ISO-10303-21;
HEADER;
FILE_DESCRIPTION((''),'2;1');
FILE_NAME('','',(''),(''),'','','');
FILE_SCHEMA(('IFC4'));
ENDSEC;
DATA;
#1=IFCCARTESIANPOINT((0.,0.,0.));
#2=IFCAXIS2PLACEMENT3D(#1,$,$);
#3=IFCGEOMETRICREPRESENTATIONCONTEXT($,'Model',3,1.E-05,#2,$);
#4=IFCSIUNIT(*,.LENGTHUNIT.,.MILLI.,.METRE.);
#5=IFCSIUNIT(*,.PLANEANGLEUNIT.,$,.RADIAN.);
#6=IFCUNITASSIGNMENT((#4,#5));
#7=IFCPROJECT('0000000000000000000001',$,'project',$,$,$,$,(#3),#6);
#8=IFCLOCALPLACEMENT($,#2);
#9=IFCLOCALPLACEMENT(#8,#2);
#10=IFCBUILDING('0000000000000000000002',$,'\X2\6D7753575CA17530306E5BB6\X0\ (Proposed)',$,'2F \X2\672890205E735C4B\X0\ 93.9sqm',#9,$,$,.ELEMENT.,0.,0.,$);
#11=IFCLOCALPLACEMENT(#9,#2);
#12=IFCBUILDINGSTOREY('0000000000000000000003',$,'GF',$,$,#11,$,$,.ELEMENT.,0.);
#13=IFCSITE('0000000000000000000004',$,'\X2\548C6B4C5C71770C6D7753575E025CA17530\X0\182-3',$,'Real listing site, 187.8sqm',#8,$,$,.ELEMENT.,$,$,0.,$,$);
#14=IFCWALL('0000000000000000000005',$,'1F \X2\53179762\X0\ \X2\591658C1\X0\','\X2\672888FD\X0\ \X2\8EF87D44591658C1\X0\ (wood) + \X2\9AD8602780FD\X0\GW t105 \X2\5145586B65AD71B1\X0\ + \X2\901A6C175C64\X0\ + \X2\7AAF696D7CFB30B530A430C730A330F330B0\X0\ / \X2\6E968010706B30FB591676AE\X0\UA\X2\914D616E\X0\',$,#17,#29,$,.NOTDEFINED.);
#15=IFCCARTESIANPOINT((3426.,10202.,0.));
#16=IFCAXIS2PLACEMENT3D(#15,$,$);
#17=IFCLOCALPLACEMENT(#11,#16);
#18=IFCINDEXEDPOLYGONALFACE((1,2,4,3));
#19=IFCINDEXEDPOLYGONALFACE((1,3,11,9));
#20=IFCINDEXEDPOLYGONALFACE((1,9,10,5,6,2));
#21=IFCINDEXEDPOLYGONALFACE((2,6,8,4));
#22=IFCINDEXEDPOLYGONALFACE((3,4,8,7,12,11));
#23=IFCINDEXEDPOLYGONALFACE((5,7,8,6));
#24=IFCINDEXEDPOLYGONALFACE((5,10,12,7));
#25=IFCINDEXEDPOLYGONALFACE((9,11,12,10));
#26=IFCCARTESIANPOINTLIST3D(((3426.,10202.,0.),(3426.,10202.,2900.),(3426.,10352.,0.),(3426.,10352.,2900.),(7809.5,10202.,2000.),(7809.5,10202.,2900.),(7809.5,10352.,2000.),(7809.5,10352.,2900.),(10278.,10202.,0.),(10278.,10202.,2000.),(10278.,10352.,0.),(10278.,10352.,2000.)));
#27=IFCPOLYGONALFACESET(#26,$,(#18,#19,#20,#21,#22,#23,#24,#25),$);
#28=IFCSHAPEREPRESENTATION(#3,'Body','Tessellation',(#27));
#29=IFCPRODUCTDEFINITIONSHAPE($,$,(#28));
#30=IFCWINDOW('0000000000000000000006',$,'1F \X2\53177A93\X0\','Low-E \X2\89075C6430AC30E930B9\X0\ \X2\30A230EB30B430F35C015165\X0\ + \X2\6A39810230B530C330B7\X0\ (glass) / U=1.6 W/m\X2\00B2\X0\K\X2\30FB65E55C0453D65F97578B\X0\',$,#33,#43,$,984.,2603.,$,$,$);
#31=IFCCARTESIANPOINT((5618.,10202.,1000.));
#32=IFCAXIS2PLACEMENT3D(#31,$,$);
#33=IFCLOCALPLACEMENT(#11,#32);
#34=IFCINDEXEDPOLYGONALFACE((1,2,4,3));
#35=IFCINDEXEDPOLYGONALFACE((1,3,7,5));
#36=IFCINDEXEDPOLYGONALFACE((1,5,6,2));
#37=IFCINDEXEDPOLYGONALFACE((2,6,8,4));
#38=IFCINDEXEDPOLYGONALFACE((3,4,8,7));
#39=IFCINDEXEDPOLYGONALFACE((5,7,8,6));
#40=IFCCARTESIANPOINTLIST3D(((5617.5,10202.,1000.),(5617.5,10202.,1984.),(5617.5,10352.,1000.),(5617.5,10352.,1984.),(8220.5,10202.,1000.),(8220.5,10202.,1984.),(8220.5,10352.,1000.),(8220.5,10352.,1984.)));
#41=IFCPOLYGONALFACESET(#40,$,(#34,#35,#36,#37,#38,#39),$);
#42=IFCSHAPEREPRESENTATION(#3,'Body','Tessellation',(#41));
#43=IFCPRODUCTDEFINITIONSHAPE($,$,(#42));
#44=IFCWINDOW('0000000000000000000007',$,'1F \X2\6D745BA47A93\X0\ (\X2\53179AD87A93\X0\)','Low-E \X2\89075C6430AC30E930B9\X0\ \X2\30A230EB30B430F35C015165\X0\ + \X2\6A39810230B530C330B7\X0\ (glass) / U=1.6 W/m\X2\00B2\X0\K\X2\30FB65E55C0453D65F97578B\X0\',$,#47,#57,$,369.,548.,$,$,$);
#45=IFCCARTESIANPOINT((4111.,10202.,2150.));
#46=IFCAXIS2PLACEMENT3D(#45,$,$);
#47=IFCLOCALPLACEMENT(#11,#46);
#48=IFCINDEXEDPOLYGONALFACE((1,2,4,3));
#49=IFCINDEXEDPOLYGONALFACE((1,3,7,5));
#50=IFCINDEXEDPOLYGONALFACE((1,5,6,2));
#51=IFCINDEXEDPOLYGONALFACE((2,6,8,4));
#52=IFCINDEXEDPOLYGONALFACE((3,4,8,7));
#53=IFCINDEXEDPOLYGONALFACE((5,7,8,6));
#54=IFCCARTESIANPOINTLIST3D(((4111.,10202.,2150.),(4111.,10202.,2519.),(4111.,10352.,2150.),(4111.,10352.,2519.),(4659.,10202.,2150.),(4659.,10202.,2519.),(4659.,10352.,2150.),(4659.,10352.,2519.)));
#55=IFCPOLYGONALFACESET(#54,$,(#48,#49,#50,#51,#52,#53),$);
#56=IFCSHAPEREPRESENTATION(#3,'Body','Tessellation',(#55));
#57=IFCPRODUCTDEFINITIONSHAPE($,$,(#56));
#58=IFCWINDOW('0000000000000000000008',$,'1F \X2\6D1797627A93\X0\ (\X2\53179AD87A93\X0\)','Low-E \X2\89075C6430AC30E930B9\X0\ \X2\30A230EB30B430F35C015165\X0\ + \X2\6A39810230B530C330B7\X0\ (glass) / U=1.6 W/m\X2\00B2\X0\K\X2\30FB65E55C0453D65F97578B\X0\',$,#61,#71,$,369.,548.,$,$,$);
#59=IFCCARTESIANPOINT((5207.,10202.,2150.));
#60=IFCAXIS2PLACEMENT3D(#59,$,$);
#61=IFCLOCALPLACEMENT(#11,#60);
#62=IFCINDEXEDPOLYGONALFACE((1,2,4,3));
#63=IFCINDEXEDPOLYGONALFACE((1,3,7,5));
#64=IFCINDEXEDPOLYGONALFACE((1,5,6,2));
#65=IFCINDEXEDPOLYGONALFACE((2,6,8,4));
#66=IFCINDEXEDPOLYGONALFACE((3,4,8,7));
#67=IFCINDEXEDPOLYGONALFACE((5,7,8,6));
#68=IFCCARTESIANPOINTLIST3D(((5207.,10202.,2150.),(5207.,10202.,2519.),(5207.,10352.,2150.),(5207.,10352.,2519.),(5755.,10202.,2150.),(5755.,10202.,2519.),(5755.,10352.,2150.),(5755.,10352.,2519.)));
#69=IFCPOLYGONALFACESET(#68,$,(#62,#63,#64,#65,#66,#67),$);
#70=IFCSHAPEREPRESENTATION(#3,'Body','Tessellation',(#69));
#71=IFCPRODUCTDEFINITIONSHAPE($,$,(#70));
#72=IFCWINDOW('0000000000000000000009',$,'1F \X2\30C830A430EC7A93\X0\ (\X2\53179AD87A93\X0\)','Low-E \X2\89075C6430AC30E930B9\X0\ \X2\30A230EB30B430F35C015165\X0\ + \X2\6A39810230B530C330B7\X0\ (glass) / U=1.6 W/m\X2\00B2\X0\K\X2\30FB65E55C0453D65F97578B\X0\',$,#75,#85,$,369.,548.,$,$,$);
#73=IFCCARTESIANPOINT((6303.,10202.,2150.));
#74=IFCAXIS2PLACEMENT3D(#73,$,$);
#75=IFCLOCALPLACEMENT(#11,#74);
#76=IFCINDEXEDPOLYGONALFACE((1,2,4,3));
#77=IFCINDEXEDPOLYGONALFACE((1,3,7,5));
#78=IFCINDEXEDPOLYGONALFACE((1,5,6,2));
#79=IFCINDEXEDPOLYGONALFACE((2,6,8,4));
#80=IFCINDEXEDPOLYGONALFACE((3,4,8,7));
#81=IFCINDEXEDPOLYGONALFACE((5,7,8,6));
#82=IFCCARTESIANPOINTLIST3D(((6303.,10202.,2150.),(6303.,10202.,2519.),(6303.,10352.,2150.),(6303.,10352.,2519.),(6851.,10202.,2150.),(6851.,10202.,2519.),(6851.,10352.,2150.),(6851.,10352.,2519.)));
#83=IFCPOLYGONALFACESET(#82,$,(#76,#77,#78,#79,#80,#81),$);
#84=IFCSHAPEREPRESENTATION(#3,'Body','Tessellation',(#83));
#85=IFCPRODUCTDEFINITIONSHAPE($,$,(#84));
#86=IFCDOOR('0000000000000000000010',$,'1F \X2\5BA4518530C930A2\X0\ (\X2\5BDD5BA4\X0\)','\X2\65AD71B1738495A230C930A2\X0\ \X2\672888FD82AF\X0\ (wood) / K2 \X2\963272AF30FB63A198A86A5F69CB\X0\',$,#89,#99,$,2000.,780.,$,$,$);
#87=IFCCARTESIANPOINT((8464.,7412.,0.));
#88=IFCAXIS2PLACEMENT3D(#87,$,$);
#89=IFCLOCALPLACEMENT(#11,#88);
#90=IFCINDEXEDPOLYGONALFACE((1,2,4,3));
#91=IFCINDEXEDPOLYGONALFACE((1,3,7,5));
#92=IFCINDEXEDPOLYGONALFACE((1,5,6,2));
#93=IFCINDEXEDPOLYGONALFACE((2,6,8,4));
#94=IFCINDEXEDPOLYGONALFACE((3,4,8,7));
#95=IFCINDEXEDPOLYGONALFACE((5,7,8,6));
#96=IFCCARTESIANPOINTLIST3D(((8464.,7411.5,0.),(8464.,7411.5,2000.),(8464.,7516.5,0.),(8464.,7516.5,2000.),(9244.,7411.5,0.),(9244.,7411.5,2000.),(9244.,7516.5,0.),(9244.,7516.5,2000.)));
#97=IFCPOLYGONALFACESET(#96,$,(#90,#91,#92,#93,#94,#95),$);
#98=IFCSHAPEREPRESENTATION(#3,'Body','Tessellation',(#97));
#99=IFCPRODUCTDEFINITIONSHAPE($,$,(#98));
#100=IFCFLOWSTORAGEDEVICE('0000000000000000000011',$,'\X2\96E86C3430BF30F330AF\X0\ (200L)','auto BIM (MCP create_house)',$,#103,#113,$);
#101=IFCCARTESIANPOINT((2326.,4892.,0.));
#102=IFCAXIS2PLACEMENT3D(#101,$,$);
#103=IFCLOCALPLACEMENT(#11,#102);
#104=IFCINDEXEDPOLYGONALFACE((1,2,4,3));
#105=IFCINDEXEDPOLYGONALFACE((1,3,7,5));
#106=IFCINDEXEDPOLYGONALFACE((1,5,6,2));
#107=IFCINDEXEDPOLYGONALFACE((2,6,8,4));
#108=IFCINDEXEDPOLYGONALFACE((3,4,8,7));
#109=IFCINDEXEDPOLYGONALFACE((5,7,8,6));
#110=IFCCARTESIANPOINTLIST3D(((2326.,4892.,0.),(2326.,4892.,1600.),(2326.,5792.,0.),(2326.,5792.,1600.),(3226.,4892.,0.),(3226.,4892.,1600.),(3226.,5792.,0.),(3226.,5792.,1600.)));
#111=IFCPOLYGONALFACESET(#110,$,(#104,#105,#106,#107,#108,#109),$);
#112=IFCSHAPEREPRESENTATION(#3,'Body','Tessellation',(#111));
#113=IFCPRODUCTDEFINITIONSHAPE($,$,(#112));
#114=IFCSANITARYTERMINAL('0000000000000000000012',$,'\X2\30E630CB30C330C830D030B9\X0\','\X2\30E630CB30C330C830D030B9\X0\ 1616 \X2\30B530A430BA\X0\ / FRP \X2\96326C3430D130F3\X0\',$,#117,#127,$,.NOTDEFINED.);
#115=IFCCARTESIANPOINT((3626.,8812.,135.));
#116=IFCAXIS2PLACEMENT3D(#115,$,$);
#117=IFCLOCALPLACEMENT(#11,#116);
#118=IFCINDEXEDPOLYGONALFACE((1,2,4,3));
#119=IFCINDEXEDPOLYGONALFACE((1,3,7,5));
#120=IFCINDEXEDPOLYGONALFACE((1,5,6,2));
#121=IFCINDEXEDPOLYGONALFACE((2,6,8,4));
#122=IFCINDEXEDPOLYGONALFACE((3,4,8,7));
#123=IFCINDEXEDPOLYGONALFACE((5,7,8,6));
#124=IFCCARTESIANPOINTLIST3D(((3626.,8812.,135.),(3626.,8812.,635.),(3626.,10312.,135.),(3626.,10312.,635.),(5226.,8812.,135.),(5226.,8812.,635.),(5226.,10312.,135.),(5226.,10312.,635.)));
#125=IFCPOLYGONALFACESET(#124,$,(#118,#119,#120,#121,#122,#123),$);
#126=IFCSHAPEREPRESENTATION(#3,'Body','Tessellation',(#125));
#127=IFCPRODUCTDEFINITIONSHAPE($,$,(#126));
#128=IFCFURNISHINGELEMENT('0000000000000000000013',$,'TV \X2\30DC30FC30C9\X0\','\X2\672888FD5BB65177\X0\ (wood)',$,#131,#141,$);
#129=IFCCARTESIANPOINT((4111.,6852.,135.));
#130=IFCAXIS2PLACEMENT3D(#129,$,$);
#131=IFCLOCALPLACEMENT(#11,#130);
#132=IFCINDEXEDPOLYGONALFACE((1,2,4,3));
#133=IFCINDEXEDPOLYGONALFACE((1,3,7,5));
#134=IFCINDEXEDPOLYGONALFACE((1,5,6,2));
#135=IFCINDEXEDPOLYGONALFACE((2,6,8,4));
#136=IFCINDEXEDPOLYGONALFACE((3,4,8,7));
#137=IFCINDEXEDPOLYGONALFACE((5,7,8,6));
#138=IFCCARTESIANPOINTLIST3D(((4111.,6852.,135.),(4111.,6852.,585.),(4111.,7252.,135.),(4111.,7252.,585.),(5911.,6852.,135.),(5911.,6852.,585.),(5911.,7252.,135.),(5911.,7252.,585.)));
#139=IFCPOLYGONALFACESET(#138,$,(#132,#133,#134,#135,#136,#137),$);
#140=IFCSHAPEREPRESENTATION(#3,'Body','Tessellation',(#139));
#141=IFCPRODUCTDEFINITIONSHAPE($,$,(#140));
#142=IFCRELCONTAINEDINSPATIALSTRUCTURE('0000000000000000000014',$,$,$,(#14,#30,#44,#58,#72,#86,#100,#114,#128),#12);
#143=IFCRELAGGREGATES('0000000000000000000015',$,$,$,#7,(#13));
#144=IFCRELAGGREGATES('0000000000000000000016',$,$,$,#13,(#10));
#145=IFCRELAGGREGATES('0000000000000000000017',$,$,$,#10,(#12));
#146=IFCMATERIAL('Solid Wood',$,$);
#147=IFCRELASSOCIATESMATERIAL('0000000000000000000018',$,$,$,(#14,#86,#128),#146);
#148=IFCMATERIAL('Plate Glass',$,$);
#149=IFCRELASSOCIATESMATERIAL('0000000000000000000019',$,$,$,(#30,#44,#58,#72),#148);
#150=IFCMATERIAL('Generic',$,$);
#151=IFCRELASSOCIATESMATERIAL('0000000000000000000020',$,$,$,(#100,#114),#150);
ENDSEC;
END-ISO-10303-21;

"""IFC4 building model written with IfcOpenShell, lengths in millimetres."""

from ifc_helpers import new_model, si_unit, frame, frame_2d, origin, place, context, project, spatial, rectangle, extrude, material, element, fill, save


model = new_model("IFC4")

# Units and contexts
model_context = context("Model", 3, precision=1e-05, world=origin())
ifc_project = project(units=[si_unit("LENGTHUNIT", "METRE", prefix="MILLI"), si_unit("PLANEANGLEUNIT", "RADIAN")], contexts=[model_context])

# Site, building, storey
site_placement = place(None, origin())
site = spatial("IfcSite", under=ifc_project, at=site_placement, Name="和歌山県海南市岡田182-3", ObjectType="Real listing site, 187.8sqm", CompositionType="ELEMENT", RefElevation=0.0)
building_placement = place(site_placement, origin())
building = spatial("IfcBuilding", under=site, at=building_placement, Name="海南岡田の家 (Proposed)", ObjectType="2F 木造平屋 93.9sqm", CompositionType="ELEMENT", ElevationOfRefHeight=0.0, ElevationOfTerrain=0.0)
storey_placement = place(building_placement, origin())
storey = spatial("IfcBuildingStorey", under=building, at=storey_placement, Name="GF", CompositionType="ELEMENT", Elevation=0.0)

# Wall, openings, windows
ifc_material_1 = material(Name="Solid Wood")
wall_1_placement = place(storey_placement, frame((3426.0, 10202.0, 0.0)))
wall_1 = element("IfcWall", 1, at=wall_1_placement, inside=storey, material=ifc_material_1, Name="1F 北面 外壁", Description="木製 軸組外壁 (wood) + 高性能GW t105 充填断熱 + 通気層 + 窯業系サイディング / 準耐火・外皮UA配慮", PredefinedType="NOTDEFINED", context=model_context, shape_type="SweptSolid", body=[
    extrude(rectangle(XDim=6852.0, YDim=150.0, at=frame_2d((3426.0, 75.0))), frame((3426.0, 10202.0, 0.0)), (0.0, 0.0, 1.0), 2900.0),
])
opening_1_placement = place(storey_placement, frame((5618.0, 10202.0, 1000.0)))
opening_1 = element("IfcOpeningElement", 2, at=opening_1_placement, cuts=wall_1, PredefinedType="NOTDEFINED", context=model_context, shape_type="SweptSolid", body=[
    extrude(rectangle(XDim=2603.0, YDim=150.0, at=frame_2d((1301.0, 75.0))), frame((5618.0, 10202.0, 1000.0)), (0.0, 0.0, 1.0), 984.0),
])
opening_2_placement = place(storey_placement, frame((4111.0, 10202.0, 2150.0)))
opening_2 = element("IfcOpeningElement", 3, at=opening_2_placement, cuts=wall_1, PredefinedType="NOTDEFINED", context=model_context, shape_type="SweptSolid", body=[
    extrude(rectangle(XDim=548.0, YDim=150.0, at=frame_2d((274.0, 75.0))), frame((4111.0, 10202.0, 2150.0)), (0.0, 0.0, 1.0), 369.0),
])
opening_3_placement = place(storey_placement, frame((5207.0, 10202.0, 2150.0)))
opening_3 = element("IfcOpeningElement", 4, at=opening_3_placement, cuts=wall_1, PredefinedType="NOTDEFINED", context=model_context, shape_type="SweptSolid", body=[
    extrude(rectangle(XDim=548.0, YDim=150.0, at=frame_2d((274.0, 75.0))), frame((5207.0, 10202.0, 2150.0)), (0.0, 0.0, 1.0), 369.0),
])
opening_4_placement = place(storey_placement, frame((6303.0, 10202.0, 2150.0)))
opening_4 = element("IfcOpeningElement", 5, at=opening_4_placement, cuts=wall_1, PredefinedType="NOTDEFINED", context=model_context, shape_type="SweptSolid", body=[
    extrude(rectangle(XDim=548.0, YDim=150.0, at=frame_2d((274.0, 75.0))), frame((6303.0, 10202.0, 2150.0)), (0.0, 0.0, 1.0), 369.0),
])
ifc_material_2 = material(Name="Plate Glass")
window_1_placement = place(storey_placement, frame((5618.0, 10202.0, 1000.0)))
window_1 = element("IfcWindow", 6, at=window_1_placement, inside=storey, material=ifc_material_2, Name="1F 北窓", Description="Low-E 複層ガラス アルゴン封入 + 樹脂サッシ (glass) / U=1.6 W/m²K・日射取得型", OverallHeight=984.0, OverallWidth=2603.0, context=model_context, shape_type="SweptSolid", body=[
    extrude(rectangle(XDim=2603.0, YDim=150.0, at=frame_2d((1301.0, 75.0))), frame((5618.0, 10202.0, 1000.0)), (0.0, 0.0, 1.0), 984.0),
])
fill(opening_1, window_1)
window_2_placement = place(storey_placement, frame((4111.0, 10202.0, 2150.0)))
window_2 = element("IfcWindow", 7, at=window_2_placement, inside=storey, material=ifc_material_2, Name="1F 浴室窓 (北高窓)", Description="Low-E 複層ガラス アルゴン封入 + 樹脂サッシ (glass) / U=1.6 W/m²K・日射取得型", OverallHeight=369.0, OverallWidth=548.0, context=model_context, shape_type="SweptSolid", body=[
    extrude(rectangle(XDim=548.0, YDim=150.0, at=frame_2d((274.0, 75.0))), frame((4111.0, 10202.0, 2150.0)), (0.0, 0.0, 1.0), 369.0),
])
fill(opening_2, window_2)
window_3_placement = place(storey_placement, frame((5207.0, 10202.0, 2150.0)))
window_3 = element("IfcWindow", 8, at=window_3_placement, inside=storey, material=ifc_material_2, Name="1F 洗面窓 (北高窓)", Description="Low-E 複層ガラス アルゴン封入 + 樹脂サッシ (glass) / U=1.6 W/m²K・日射取得型", OverallHeight=369.0, OverallWidth=548.0, context=model_context, shape_type="SweptSolid", body=[
    extrude(rectangle(XDim=548.0, YDim=150.0, at=frame_2d((274.0, 75.0))), frame((5207.0, 10202.0, 2150.0)), (0.0, 0.0, 1.0), 369.0),
])
fill(opening_3, window_3)
window_4_placement = place(storey_placement, frame((6303.0, 10202.0, 2150.0)))
window_4 = element("IfcWindow", 9, at=window_4_placement, inside=storey, material=ifc_material_2, Name="1F トイレ窓 (北高窓)", Description="Low-E 複層ガラス アルゴン封入 + 樹脂サッシ (glass) / U=1.6 W/m²K・日射取得型", OverallHeight=369.0, OverallWidth=548.0, context=model_context, shape_type="SweptSolid", body=[
    extrude(rectangle(XDim=548.0, YDim=150.0, at=frame_2d((274.0, 75.0))), frame((6303.0, 10202.0, 2150.0)), (0.0, 0.0, 1.0), 369.0),
])
fill(opening_4, window_4)

# Door
door_1_placement = place(storey_placement, frame((8464.0, 7412.0, 0.0)))
element("IfcDoor", 10, at=door_1_placement, inside=storey, material=ifc_material_1, Name="1F 室内ドア (寝室)", Description="断熱玄関ドア 木製芯 (wood) / K2 防犯・採風機構", OverallHeight=2000.0, OverallWidth=780.0, context=model_context, shape_type="SweptSolid", body=[
    extrude(rectangle(XDim=780.0, YDim=105.0, at=frame_2d((390.0, 52.0))), frame((8464.0, 7412.0, 0.0)), (0.0, 0.0, 1.0), 2000.0),
])

# Flow storage device
ifc_material_3 = material(Name="Generic")
flow_storage_device_placement = place(storey_placement, frame((2326.0, 4892.0, 0.0)))
element("IfcFlowStorageDevice", 11, at=flow_storage_device_placement, inside=storey, material=ifc_material_3, Name="雨水タンク (200L)", Description="auto BIM (MCP create_house)", context=model_context, shape_type="SweptSolid", body=[
    extrude(rectangle(XDim=900.0, YDim=900.0, at=frame_2d((450.0, 450.0))), frame((2326.0, 4892.0, 0.0)), (0.0, 0.0, 1.0), 1600.0),
])

# Sanitary terminal
sanitary_terminal_placement = place(storey_placement, frame((3626.0, 8812.0, 135.0)))
element("IfcSanitaryTerminal", 12, at=sanitary_terminal_placement, inside=storey, material=ifc_material_3, Name="ユニットバス", Description="ユニットバス 1616 サイズ / FRP 防水パン", PredefinedType="NOTDEFINED", context=model_context, shape_type="SweptSolid", body=[
    extrude(rectangle(XDim=1600.0, YDim=1500.0, at=frame_2d((800.0, 750.0))), frame((3626.0, 8812.0, 135.0)), (0.0, 0.0, 1.0), 500.0),
])

# Furnishing element
furnishing_placement = place(storey_placement, frame((4111.0, 6852.0, 135.0)))
element("IfcFurnishingElement", 13, at=furnishing_placement, inside=storey, material=ifc_material_1, Name="TV ボード", Description="木製家具 (wood)", context=model_context, shape_type="SweptSolid", body=[
    extrude(rectangle(XDim=1800.0, YDim=400.0, at=frame_2d((900.0, 200.0))), frame((4111.0, 6852.0, 135.0)), (0.0, 0.0, 1.0), 450.0),
])

save(model, "model.ifc")
